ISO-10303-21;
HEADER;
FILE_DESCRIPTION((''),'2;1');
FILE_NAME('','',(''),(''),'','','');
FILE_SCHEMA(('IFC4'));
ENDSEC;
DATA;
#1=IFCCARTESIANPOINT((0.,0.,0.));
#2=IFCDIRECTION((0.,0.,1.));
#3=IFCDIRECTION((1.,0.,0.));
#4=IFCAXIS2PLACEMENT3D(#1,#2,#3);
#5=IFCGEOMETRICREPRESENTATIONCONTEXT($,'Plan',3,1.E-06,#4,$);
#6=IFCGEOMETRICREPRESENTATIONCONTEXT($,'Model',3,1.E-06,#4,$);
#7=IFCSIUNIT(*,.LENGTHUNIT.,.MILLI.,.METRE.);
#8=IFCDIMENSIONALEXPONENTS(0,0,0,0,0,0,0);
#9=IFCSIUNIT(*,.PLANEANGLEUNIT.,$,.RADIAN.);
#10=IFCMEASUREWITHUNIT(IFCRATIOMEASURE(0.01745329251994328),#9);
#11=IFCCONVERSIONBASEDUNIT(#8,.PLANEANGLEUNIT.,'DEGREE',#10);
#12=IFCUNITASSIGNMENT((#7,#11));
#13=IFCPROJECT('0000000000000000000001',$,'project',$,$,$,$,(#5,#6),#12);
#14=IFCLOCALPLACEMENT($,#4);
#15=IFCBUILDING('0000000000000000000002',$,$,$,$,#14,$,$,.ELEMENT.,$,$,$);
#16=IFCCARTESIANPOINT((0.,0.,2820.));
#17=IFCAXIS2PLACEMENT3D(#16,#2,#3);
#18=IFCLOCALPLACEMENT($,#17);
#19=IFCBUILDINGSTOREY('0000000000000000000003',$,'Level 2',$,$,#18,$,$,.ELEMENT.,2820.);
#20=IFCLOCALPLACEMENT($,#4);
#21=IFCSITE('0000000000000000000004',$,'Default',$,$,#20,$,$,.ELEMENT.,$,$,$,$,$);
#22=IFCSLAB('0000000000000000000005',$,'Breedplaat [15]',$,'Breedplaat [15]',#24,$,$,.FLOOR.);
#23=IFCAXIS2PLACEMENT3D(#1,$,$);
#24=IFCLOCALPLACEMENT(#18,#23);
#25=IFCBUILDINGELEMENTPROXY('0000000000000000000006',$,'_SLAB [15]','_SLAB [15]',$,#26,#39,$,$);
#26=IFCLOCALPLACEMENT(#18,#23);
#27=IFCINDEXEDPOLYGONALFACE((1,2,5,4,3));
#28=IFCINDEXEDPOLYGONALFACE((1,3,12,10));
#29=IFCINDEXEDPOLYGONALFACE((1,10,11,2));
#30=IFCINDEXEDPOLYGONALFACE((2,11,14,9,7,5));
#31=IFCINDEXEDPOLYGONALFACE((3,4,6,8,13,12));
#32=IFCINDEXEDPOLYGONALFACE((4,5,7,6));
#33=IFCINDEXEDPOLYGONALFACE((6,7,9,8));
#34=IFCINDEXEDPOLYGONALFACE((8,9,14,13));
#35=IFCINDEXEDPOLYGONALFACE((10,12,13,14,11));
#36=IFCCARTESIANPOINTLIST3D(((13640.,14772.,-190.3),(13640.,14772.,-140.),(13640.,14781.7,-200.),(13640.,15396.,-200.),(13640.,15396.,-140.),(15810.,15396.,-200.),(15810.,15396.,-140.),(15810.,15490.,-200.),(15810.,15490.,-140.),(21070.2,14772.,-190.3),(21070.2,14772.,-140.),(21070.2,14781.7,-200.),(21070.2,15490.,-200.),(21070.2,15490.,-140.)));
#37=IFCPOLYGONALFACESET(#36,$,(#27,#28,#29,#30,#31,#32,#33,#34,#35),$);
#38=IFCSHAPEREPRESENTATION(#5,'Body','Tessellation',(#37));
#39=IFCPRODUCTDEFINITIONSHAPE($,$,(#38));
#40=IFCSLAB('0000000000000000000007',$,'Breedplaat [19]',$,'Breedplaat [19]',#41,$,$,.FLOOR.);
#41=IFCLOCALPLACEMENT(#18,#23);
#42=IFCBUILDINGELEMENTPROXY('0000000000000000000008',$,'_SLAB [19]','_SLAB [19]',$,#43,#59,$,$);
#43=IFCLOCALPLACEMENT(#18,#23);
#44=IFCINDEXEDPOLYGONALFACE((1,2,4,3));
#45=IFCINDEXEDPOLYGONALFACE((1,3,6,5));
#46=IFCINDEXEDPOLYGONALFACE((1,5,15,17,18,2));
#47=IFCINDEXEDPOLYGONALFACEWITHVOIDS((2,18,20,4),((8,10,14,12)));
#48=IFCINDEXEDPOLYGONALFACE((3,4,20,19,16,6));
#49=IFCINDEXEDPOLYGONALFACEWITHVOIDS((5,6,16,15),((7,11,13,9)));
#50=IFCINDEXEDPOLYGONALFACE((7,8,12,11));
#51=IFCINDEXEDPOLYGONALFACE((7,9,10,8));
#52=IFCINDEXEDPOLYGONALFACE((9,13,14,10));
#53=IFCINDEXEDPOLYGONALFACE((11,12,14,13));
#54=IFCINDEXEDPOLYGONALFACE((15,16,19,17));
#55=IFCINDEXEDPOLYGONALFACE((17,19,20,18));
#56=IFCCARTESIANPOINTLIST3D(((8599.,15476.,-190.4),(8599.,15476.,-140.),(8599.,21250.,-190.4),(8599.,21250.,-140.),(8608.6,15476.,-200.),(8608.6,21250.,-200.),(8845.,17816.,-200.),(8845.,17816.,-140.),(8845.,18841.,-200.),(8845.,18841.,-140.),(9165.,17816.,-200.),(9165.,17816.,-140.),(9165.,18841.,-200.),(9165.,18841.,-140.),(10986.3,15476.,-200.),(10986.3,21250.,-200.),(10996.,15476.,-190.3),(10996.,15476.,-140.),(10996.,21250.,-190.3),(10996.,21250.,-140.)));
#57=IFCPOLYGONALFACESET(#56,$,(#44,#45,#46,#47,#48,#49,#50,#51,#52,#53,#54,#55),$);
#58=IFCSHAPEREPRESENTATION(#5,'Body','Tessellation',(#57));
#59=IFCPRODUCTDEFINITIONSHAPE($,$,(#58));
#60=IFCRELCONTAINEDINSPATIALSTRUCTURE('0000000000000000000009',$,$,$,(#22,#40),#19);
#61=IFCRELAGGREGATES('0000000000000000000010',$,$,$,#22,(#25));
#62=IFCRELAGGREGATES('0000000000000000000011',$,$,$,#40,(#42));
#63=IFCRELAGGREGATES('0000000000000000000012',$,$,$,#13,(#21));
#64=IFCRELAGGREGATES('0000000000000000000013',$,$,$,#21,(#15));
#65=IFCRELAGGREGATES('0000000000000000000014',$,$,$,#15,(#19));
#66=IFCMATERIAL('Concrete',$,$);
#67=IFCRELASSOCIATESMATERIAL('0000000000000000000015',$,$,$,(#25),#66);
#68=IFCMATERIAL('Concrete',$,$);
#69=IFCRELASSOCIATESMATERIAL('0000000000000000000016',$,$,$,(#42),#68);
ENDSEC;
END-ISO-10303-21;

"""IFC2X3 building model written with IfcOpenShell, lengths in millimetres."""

from ifc_helpers import new_model, entity, si_unit, converted_unit, frame, origin_with_axes, origin_2d_with_axis, place, context, project, spatial, polyline, rectangle, outline, extrude, material, element, aggregate, save


model = new_model("IFC2X3")

# Units and contexts
plan_context = context("Plan", 3, precision=1e-06, world=origin_with_axes())
model_context = context("Model", 3, precision=1e-06, world=origin_with_axes())
ifc_project = project(units=[si_unit("LENGTHUNIT", "METRE", prefix="MILLI"), converted_unit("PLANEANGLEUNIT", "DEGREE", entity("IfcRatioMeasure", 0.01745329251994328), si_unit("PLANEANGLEUNIT", "RADIAN"), dimensions=[0, 0, 0, 0, 0, 0, 0])], contexts=[plan_context, model_context])

# Site, building, storey
site_placement = place(None, origin_with_axes())
site = spatial("IfcSite", under=ifc_project, at=site_placement, Name="Default", CompositionType="ELEMENT")
building_placement = place(None, origin_with_axes())
building = spatial("IfcBuilding", under=site, at=building_placement, CompositionType="ELEMENT")
storey_placement = place(None, frame((0.0, 0.0, 2820.0), z_axis=(0.0, 0.0, 1.0), x_axis=(1.0, 0.0, 0.0)))
storey = spatial("IfcBuildingStorey", under=building, at=storey_placement, Name="Level 2", CompositionType="ELEMENT", Elevation=2820.0)

# Slab, building element proxy, opening
slab_1_placement = place(None, frame((13640.0, 14772.0, 2620.0), z_axis=(0.0, 0.0, 1.0), x_axis=(1.0, 0.0, 0.0)))
slab_1 = element("IfcSlab", 1, at=slab_1_placement, inside=storey, Name="Breedplaat [15]", ObjectType="Breedplaat [15]", PredefinedType="FLOOR")
ifc_material_1 = material(Name="Concrete")
proxy_1_placement = place(slab_1_placement, origin_with_axes())
proxy_1 = element("IfcBuildingElementProxy", 2, at=proxy_1_placement, material=ifc_material_1, Name="_SLAB [15]", Description="_SLAB [15]", context=plan_context, shape_type="SweptSolid", body=[
    extrude(outline(polyline([(2170.0, 718.0), (2170.0, 624.0), (0.0, 624.0), (0.0, 0.0), (7430.1, 0.0), (7430.1, 718.0), (2170.0, 718.0)])), origin_with_axes(), (0.0, 0.0, 1.0), 60.0),
])
opening_1_placement = place(None, frame((13640.0, 14772.0, 2620.0), z_axis=(0.0, 0.0, 1.0), x_axis=(1.0, 0.0, 0.0)))
element("IfcOpeningElement", 3, at=opening_1_placement, cuts=proxy_1, ObjectType="Opening", context=plan_context, shape_type="SweptSolid", body=[
    extrude(outline(polyline([(-0.1, -0.1), (-0.1, 10.0), (10.0, -0.1), (-0.1, -0.1)])), frame((-1.2, -0.1, -0.1), z_axis=(1.0, 0.0, 0.0), x_axis=(0.0, 1.0, 0.0)), (0.0, 0.0, 1.0), 7432.4),
])
aggregate(slab_1, [proxy_1])

# Slab, building element proxy, openings
slab_2_placement = place(None, frame((10996.0, 15476.0, 2620.0), z_axis=(0.0, 0.0, 1.0), x_axis=(0.0, 1.0, 0.0)))
slab_2 = element("IfcSlab", 4, at=slab_2_placement, inside=storey, Name="Breedplaat [19]", ObjectType="Breedplaat [19]", PredefinedType="FLOOR")
ifc_material_2 = material(Name="Concrete")
proxy_2_placement = place(slab_2_placement, origin_with_axes())
proxy_2 = element("IfcBuildingElementProxy", 5, at=proxy_2_placement, material=ifc_material_2, Name="_SLAB [19]", Description="_SLAB [19]", context=plan_context, shape_type="SweptSolid", body=[
    extrude(outline(polyline([(0.0, 2397.0), (0.0, 0.0), (5774.0, 0.0), (5774.0, 2397.0), (0.0, 2397.0)])), origin_with_axes(), (0.0, 0.0, 1.0), 60.0),
])
opening_2_placement = place(slab_2_placement, frame((3365.0, 1831.0, 0.0), z_axis=(0.0, 0.0, 1.0), x_axis=(0.0, 1.0, 0.0)))
element("IfcOpeningElement", 6, at=opening_2_placement, cuts=proxy_2, ObjectType="Opening", context=plan_context, shape_type="SolidModel", body=[
    extrude(rectangle(XDim=320.0, YDim=1025.0, at=origin_2d_with_axis()), frame((160.0, 512.5, 0.0), z_axis=(0.0, 0.0, 1.0), x_axis=(1.0, 0.0, 0.0)), (0.0, 0.0, 1.0), 60.0),
])
opening_3_placement = place(None, frame((10996.0, 15476.0, 2620.0), z_axis=(0.0, 0.0, 1.0), x_axis=(0.0, 1.0, 0.0)))
element("IfcOpeningElement", 7, at=opening_3_placement, cuts=proxy_2, ObjectType="Opening", context=plan_context, shape_type="SweptSolid", body=[
    extrude(outline(polyline([(-0.1, -0.1), (-0.1, 10.0), (10.0, -0.1), (-0.1, -0.1)])), frame((-1.2, -0.1, -0.1), z_axis=(1.0, 0.0, 0.0), x_axis=(0.0, 1.0, 0.0)), (0.0, 0.0, 1.0), 5776.2),
])
opening_4_placement = place(None, frame((10996.0, 15476.0, 2620.0), z_axis=(0.0, 0.0, 1.0), x_axis=(0.0, 1.0, 0.0)))
element("IfcOpeningElement", 8, at=opening_4_placement, cuts=proxy_2, ObjectType="Opening", context=plan_context, shape_type="SweptSolid", body=[
    extrude(outline(polyline([(-0.1, -0.1), (-0.1, 10.0), (10.0, -0.1), (-0.1, -0.1)])), frame((5775.2, 2397.2, -0.1), z_axis=(-1.0, 0.0, 0.0), x_axis=(0.0, -1.0, 0.0)), (0.0, 0.0, 1.0), 5776.2),
])
aggregate(slab_2, [proxy_2])

save(model, "model.ifc")
